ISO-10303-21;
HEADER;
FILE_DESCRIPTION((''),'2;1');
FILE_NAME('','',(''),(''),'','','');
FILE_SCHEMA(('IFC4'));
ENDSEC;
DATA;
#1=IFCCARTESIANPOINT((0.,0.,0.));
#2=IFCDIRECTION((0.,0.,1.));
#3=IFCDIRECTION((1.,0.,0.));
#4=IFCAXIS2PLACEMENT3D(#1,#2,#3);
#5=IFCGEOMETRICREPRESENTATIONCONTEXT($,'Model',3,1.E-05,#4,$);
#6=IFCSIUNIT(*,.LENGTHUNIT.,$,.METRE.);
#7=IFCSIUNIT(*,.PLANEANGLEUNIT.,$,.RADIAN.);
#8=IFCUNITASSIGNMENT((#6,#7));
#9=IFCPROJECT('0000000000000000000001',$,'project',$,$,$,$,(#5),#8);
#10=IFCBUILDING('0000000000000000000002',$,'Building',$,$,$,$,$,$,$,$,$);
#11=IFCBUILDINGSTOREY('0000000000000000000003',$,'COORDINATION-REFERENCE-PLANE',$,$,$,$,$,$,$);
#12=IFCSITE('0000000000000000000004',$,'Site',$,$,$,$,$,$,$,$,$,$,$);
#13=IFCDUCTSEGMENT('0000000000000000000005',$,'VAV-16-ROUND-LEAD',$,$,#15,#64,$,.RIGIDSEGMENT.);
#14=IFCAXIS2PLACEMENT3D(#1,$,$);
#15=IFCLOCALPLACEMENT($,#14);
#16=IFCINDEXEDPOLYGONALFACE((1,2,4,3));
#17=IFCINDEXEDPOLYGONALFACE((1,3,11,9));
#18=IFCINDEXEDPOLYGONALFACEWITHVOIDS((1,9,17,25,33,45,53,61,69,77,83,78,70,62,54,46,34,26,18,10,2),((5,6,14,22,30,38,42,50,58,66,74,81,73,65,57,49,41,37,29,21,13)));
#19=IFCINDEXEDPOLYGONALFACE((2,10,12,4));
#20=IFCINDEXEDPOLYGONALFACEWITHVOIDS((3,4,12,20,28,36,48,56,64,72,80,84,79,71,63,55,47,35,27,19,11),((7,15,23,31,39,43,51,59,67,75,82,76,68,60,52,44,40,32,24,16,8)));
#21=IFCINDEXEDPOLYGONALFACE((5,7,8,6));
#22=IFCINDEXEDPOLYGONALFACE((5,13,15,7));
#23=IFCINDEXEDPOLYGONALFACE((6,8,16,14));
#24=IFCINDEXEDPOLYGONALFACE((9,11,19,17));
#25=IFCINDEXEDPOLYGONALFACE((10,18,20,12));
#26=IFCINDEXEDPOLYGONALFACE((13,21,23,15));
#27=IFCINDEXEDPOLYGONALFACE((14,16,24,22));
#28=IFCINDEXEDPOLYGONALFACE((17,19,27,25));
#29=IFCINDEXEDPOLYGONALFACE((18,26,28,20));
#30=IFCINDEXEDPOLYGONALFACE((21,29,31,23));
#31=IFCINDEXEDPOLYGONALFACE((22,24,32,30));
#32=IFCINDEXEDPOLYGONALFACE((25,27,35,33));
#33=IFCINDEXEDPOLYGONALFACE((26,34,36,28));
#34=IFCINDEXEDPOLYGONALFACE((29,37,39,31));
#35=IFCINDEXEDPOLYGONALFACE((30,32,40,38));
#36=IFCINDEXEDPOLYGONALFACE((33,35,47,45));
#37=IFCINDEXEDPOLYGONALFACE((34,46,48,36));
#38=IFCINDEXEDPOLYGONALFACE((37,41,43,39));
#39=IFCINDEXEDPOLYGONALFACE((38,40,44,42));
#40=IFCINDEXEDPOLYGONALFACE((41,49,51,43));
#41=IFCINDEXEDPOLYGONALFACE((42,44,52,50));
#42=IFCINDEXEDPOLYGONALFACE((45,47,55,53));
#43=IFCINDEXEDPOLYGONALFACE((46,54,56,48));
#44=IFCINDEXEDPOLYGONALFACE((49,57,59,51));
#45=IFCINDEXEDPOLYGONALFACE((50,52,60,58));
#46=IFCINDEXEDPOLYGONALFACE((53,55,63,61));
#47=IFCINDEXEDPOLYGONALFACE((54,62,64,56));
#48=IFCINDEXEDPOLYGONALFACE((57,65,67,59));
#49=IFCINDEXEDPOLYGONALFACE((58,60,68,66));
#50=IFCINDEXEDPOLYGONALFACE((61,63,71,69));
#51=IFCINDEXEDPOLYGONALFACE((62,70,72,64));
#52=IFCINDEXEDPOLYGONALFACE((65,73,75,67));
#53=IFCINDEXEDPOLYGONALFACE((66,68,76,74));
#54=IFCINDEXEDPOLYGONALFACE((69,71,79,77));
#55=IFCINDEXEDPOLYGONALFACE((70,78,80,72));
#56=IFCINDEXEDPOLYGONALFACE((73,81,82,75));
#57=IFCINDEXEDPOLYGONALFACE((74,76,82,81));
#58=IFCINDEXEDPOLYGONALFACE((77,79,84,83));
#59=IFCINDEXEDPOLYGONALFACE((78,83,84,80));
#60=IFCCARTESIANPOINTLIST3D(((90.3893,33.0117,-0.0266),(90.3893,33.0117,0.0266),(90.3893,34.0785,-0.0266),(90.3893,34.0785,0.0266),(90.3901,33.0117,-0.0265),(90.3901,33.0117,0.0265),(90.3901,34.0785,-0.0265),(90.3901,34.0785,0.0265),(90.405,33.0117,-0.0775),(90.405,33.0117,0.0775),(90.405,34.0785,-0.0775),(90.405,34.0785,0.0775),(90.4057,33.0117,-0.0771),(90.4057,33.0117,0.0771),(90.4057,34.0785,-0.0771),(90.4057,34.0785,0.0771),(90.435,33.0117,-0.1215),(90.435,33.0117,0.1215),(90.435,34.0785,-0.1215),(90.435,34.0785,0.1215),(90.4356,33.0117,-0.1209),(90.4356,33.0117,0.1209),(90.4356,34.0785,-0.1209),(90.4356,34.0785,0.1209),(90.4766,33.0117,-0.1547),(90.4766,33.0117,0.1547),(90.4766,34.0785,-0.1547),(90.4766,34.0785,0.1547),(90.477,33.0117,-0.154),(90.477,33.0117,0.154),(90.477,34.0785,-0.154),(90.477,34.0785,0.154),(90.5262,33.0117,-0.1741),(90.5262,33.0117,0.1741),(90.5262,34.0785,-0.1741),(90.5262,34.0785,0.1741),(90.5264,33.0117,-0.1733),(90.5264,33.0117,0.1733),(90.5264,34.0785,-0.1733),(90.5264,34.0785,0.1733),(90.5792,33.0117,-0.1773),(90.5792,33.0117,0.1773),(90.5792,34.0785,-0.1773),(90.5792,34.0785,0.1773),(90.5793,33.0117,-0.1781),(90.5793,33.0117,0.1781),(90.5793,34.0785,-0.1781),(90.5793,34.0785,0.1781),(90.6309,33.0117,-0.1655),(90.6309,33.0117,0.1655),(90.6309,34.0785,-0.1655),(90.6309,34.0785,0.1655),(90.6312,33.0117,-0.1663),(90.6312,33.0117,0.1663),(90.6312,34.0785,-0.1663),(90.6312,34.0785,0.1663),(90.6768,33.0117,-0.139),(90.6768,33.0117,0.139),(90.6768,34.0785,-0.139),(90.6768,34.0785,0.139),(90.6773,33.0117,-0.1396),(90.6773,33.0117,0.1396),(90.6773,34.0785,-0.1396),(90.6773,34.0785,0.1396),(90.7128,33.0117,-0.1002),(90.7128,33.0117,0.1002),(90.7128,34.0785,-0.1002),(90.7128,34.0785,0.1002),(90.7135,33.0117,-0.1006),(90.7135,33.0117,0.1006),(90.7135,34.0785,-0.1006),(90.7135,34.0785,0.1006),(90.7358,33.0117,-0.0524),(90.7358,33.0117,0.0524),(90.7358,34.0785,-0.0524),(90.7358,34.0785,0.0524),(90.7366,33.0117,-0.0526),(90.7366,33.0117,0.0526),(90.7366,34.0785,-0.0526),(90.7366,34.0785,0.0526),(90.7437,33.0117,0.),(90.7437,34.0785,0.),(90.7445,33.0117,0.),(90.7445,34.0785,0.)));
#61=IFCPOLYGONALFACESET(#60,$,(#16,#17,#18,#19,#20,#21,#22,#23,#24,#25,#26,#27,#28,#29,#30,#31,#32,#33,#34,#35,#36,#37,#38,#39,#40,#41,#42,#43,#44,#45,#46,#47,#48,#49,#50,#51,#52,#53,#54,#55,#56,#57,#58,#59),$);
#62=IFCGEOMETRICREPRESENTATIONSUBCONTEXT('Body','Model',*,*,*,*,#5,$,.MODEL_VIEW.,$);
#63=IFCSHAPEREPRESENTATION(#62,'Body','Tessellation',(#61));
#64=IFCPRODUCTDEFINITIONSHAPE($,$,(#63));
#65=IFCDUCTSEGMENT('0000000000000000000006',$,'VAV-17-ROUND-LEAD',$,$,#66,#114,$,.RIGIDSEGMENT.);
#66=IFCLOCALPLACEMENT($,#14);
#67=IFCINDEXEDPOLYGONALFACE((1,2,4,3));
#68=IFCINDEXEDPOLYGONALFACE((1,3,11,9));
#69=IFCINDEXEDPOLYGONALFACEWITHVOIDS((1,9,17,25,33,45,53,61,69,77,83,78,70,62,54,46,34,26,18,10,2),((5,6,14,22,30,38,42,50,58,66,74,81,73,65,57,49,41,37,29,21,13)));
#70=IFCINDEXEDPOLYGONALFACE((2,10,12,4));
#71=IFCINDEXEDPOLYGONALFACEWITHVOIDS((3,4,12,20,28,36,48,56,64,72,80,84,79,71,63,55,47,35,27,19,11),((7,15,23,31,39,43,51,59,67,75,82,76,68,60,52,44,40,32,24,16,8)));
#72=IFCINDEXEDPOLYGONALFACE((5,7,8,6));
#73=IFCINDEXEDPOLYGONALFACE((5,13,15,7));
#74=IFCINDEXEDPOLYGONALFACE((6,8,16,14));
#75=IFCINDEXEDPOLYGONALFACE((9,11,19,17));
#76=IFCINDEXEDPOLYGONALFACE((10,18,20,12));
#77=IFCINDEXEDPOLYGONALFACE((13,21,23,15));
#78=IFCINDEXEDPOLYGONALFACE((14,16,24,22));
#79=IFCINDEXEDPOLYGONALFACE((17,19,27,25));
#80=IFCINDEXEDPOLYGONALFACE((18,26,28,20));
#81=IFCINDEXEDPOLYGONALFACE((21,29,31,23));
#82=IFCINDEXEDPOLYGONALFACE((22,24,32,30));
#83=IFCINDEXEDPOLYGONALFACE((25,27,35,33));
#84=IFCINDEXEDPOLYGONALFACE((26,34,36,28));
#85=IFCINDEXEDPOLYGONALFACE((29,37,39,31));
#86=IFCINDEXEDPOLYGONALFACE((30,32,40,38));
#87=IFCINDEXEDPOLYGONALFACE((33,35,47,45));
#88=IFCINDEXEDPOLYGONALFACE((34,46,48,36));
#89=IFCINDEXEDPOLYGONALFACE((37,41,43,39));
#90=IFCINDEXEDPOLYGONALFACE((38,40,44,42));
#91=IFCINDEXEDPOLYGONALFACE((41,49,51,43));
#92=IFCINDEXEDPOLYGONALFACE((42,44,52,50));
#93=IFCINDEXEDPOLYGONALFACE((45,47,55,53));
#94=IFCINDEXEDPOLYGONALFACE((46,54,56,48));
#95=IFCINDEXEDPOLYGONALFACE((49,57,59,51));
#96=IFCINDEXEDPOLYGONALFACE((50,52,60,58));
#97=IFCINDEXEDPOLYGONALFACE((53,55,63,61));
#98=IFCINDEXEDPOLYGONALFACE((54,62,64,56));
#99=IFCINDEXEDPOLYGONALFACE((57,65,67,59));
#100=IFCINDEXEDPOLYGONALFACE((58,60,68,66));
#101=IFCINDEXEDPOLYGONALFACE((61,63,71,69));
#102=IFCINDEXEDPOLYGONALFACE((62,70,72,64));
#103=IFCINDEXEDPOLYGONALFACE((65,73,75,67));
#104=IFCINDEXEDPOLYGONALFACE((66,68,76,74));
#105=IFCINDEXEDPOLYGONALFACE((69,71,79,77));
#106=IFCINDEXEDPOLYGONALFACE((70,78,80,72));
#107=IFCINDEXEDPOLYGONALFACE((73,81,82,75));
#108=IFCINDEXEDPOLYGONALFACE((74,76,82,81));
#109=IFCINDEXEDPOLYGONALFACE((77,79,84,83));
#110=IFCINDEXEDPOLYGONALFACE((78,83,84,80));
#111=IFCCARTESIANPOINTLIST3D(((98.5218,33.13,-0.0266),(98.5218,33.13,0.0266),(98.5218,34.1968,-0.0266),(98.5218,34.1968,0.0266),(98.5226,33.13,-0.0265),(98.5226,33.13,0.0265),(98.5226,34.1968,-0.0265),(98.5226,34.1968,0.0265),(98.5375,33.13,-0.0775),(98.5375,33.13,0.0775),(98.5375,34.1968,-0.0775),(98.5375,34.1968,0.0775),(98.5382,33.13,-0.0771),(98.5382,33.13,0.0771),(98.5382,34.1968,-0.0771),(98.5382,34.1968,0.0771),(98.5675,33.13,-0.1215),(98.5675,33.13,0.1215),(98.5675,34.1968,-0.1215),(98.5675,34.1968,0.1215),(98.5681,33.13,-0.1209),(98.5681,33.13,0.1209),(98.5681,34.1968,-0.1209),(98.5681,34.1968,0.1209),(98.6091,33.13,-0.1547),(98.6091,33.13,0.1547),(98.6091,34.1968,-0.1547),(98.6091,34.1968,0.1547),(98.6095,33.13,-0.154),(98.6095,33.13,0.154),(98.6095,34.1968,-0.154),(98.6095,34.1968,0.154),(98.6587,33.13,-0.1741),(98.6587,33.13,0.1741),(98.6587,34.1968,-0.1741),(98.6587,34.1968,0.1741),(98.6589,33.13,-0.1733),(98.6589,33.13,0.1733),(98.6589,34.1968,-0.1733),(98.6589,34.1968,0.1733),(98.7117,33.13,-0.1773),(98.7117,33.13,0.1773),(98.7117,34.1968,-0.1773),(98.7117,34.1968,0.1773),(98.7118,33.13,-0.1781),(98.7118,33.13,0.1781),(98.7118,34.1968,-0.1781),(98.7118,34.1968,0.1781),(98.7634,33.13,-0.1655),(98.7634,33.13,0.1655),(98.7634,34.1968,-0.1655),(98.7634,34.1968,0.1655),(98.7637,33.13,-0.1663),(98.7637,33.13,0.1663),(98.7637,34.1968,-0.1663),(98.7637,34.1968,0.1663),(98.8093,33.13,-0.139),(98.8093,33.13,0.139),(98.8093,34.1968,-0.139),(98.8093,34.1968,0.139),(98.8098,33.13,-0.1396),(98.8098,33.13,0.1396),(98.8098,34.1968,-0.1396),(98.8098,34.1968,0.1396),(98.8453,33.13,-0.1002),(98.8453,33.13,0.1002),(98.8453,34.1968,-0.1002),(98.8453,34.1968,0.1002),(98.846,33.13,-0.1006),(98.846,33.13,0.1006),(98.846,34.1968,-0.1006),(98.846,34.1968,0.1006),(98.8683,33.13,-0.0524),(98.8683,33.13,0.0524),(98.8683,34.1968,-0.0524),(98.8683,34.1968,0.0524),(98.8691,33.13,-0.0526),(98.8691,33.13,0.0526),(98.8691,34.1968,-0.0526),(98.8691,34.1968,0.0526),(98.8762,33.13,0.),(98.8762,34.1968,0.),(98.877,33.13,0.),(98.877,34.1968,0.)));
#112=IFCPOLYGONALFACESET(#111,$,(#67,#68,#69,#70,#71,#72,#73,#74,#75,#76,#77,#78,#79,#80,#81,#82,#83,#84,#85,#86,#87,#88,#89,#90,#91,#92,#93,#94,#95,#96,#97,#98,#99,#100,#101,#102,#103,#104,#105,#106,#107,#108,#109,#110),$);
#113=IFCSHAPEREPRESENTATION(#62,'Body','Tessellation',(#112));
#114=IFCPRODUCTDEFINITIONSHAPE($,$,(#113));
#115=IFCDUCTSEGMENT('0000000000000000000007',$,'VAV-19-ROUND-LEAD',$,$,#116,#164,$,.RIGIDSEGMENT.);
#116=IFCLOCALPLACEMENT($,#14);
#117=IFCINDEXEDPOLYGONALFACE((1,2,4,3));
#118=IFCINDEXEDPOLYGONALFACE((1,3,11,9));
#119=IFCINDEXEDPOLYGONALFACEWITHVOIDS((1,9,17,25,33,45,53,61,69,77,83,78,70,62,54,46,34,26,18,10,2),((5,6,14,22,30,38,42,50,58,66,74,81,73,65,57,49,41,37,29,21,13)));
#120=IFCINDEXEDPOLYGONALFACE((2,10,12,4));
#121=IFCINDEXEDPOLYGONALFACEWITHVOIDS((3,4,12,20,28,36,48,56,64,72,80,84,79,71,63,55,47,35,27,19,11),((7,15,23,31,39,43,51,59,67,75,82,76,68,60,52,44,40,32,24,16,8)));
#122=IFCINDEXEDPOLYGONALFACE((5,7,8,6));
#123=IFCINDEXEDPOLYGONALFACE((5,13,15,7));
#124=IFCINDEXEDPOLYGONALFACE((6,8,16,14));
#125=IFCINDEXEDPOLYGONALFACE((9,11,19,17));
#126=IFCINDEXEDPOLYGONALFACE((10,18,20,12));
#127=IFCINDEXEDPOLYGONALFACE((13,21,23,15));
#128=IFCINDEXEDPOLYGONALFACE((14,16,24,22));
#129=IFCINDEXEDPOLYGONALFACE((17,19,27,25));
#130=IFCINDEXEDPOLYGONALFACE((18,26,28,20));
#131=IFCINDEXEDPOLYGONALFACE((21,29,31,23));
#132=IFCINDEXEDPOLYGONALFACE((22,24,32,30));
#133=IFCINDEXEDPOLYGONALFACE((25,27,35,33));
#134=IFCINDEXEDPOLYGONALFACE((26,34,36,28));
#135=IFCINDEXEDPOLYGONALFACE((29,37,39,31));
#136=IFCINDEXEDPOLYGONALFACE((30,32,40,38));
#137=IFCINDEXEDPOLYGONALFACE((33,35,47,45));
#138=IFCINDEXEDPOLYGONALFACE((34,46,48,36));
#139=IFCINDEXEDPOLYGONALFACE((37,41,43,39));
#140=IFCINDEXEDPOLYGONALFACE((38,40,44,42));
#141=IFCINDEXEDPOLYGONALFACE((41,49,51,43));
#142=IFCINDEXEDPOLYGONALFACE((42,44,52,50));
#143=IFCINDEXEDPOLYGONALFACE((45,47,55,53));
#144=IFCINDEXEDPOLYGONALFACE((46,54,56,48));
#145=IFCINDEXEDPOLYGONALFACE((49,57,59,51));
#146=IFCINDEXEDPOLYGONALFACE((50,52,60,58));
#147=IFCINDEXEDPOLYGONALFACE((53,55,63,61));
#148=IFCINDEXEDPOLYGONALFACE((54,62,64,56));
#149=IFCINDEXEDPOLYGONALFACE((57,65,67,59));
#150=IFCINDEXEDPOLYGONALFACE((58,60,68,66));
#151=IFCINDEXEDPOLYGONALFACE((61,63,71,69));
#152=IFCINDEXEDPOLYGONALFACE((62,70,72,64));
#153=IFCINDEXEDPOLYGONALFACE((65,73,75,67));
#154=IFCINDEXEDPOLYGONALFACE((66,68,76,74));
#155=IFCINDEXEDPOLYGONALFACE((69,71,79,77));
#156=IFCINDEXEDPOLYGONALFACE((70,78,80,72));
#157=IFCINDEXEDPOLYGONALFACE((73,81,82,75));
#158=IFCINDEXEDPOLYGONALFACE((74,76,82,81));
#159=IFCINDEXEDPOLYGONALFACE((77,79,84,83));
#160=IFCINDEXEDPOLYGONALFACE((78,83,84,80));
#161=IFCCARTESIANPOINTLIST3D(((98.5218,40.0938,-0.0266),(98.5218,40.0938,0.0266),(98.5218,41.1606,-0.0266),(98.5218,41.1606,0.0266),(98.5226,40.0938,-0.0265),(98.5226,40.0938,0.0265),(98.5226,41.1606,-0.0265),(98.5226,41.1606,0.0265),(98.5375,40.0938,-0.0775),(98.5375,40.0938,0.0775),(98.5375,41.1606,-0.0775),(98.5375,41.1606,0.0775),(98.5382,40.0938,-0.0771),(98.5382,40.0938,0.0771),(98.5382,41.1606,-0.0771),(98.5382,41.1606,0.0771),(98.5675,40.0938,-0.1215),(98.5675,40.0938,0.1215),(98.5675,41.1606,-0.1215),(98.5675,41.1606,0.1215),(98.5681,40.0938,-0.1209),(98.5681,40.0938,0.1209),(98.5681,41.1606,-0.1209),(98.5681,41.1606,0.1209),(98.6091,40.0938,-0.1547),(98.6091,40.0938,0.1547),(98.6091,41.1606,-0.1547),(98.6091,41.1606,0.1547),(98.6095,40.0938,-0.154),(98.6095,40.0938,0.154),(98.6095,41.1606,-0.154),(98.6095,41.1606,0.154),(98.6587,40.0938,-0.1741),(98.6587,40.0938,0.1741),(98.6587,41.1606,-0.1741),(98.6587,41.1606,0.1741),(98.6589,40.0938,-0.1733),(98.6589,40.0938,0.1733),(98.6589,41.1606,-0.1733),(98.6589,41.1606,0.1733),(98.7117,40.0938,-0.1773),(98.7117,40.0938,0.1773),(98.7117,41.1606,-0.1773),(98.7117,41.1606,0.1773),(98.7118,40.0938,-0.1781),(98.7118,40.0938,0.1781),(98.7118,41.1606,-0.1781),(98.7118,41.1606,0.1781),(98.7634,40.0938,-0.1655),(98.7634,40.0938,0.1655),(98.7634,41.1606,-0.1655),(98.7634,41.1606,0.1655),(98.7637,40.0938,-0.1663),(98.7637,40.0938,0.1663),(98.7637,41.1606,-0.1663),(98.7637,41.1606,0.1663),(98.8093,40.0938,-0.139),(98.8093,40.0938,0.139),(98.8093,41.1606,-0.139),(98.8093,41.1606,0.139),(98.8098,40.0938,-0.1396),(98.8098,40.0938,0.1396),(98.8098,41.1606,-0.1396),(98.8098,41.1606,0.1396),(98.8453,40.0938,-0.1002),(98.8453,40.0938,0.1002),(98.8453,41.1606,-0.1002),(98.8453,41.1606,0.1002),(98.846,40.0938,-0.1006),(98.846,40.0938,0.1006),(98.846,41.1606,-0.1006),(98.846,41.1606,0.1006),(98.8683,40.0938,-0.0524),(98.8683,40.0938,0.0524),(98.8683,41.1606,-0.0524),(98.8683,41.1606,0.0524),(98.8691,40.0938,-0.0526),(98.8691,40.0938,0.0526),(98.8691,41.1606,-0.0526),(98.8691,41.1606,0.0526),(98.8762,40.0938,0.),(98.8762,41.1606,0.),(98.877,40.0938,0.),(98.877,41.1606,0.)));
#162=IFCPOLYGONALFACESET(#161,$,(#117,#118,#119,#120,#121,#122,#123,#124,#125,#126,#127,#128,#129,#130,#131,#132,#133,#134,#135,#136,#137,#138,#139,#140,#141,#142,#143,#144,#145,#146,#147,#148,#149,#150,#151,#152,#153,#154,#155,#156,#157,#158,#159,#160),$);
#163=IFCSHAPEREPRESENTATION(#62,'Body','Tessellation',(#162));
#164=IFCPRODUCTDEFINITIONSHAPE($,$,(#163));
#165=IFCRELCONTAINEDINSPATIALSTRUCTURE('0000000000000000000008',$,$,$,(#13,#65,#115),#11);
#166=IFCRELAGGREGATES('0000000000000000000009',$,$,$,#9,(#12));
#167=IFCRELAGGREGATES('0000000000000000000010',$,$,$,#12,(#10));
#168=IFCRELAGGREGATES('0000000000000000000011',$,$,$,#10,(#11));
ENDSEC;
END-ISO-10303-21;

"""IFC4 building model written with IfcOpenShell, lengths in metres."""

from ifc_helpers import new_model, si_unit, frame, origin, origin_with_axes, place, context, subcontext, project, spatial, hollow_circle, extrude, element, save


model = new_model("IFC4")

# Units and contexts
model_context_1 = context("Model", 3, precision=1e-05, world=origin_with_axes())
body_context_1 = subcontext(model_context_1, "Body", "Model", "MODEL_VIEW")
ifc_project = project(units=[si_unit("LENGTHUNIT", "METRE"), si_unit("PLANEANGLEUNIT", "RADIAN")], contexts=[model_context_1])

# Site, building, storey
site = spatial("IfcSite", under=ifc_project, Name="Site")
building = spatial("IfcBuilding", under=site, Name="Building")
storey = spatial("IfcBuildingStorey", under=building, Name="COORDINATION-REFERENCE-PLANE")

# Duct segments
for number, where, z_axis, x_axis, name in (
    (1, (90.5659, 34.0785, 0.0), (0.0, -1.0, 0.0), (1.0, 0.0, 0.0), "VAV-16-ROUND-LEAD"),
    (2, (98.6984, 34.1968, 0.0), (0.0, -1.0, 0.0), (1.0, 0.0, 0.0), "VAV-17-ROUND-LEAD"),
    (3, (98.6984, 40.0938, 0.0), (0.0, 1.0, 0.0), (1.0, 0.0, 0.0), "VAV-19-ROUND-LEAD"),
):
    element("IfcDuctSegment", number, at=place(None, frame(where, z_axis=z_axis, x_axis=x_axis)), inside=storey, Name=name, PredefinedType="RIGIDSEGMENT", context=body_context_1, shape_type="SweptSolid", body=[
        extrude(hollow_circle(Radius=0.1786, WallThickness=0.0008), origin(), (0.0, 0.0, 1.0), 1.0668),
    ])

save(model, "model.ifc")
